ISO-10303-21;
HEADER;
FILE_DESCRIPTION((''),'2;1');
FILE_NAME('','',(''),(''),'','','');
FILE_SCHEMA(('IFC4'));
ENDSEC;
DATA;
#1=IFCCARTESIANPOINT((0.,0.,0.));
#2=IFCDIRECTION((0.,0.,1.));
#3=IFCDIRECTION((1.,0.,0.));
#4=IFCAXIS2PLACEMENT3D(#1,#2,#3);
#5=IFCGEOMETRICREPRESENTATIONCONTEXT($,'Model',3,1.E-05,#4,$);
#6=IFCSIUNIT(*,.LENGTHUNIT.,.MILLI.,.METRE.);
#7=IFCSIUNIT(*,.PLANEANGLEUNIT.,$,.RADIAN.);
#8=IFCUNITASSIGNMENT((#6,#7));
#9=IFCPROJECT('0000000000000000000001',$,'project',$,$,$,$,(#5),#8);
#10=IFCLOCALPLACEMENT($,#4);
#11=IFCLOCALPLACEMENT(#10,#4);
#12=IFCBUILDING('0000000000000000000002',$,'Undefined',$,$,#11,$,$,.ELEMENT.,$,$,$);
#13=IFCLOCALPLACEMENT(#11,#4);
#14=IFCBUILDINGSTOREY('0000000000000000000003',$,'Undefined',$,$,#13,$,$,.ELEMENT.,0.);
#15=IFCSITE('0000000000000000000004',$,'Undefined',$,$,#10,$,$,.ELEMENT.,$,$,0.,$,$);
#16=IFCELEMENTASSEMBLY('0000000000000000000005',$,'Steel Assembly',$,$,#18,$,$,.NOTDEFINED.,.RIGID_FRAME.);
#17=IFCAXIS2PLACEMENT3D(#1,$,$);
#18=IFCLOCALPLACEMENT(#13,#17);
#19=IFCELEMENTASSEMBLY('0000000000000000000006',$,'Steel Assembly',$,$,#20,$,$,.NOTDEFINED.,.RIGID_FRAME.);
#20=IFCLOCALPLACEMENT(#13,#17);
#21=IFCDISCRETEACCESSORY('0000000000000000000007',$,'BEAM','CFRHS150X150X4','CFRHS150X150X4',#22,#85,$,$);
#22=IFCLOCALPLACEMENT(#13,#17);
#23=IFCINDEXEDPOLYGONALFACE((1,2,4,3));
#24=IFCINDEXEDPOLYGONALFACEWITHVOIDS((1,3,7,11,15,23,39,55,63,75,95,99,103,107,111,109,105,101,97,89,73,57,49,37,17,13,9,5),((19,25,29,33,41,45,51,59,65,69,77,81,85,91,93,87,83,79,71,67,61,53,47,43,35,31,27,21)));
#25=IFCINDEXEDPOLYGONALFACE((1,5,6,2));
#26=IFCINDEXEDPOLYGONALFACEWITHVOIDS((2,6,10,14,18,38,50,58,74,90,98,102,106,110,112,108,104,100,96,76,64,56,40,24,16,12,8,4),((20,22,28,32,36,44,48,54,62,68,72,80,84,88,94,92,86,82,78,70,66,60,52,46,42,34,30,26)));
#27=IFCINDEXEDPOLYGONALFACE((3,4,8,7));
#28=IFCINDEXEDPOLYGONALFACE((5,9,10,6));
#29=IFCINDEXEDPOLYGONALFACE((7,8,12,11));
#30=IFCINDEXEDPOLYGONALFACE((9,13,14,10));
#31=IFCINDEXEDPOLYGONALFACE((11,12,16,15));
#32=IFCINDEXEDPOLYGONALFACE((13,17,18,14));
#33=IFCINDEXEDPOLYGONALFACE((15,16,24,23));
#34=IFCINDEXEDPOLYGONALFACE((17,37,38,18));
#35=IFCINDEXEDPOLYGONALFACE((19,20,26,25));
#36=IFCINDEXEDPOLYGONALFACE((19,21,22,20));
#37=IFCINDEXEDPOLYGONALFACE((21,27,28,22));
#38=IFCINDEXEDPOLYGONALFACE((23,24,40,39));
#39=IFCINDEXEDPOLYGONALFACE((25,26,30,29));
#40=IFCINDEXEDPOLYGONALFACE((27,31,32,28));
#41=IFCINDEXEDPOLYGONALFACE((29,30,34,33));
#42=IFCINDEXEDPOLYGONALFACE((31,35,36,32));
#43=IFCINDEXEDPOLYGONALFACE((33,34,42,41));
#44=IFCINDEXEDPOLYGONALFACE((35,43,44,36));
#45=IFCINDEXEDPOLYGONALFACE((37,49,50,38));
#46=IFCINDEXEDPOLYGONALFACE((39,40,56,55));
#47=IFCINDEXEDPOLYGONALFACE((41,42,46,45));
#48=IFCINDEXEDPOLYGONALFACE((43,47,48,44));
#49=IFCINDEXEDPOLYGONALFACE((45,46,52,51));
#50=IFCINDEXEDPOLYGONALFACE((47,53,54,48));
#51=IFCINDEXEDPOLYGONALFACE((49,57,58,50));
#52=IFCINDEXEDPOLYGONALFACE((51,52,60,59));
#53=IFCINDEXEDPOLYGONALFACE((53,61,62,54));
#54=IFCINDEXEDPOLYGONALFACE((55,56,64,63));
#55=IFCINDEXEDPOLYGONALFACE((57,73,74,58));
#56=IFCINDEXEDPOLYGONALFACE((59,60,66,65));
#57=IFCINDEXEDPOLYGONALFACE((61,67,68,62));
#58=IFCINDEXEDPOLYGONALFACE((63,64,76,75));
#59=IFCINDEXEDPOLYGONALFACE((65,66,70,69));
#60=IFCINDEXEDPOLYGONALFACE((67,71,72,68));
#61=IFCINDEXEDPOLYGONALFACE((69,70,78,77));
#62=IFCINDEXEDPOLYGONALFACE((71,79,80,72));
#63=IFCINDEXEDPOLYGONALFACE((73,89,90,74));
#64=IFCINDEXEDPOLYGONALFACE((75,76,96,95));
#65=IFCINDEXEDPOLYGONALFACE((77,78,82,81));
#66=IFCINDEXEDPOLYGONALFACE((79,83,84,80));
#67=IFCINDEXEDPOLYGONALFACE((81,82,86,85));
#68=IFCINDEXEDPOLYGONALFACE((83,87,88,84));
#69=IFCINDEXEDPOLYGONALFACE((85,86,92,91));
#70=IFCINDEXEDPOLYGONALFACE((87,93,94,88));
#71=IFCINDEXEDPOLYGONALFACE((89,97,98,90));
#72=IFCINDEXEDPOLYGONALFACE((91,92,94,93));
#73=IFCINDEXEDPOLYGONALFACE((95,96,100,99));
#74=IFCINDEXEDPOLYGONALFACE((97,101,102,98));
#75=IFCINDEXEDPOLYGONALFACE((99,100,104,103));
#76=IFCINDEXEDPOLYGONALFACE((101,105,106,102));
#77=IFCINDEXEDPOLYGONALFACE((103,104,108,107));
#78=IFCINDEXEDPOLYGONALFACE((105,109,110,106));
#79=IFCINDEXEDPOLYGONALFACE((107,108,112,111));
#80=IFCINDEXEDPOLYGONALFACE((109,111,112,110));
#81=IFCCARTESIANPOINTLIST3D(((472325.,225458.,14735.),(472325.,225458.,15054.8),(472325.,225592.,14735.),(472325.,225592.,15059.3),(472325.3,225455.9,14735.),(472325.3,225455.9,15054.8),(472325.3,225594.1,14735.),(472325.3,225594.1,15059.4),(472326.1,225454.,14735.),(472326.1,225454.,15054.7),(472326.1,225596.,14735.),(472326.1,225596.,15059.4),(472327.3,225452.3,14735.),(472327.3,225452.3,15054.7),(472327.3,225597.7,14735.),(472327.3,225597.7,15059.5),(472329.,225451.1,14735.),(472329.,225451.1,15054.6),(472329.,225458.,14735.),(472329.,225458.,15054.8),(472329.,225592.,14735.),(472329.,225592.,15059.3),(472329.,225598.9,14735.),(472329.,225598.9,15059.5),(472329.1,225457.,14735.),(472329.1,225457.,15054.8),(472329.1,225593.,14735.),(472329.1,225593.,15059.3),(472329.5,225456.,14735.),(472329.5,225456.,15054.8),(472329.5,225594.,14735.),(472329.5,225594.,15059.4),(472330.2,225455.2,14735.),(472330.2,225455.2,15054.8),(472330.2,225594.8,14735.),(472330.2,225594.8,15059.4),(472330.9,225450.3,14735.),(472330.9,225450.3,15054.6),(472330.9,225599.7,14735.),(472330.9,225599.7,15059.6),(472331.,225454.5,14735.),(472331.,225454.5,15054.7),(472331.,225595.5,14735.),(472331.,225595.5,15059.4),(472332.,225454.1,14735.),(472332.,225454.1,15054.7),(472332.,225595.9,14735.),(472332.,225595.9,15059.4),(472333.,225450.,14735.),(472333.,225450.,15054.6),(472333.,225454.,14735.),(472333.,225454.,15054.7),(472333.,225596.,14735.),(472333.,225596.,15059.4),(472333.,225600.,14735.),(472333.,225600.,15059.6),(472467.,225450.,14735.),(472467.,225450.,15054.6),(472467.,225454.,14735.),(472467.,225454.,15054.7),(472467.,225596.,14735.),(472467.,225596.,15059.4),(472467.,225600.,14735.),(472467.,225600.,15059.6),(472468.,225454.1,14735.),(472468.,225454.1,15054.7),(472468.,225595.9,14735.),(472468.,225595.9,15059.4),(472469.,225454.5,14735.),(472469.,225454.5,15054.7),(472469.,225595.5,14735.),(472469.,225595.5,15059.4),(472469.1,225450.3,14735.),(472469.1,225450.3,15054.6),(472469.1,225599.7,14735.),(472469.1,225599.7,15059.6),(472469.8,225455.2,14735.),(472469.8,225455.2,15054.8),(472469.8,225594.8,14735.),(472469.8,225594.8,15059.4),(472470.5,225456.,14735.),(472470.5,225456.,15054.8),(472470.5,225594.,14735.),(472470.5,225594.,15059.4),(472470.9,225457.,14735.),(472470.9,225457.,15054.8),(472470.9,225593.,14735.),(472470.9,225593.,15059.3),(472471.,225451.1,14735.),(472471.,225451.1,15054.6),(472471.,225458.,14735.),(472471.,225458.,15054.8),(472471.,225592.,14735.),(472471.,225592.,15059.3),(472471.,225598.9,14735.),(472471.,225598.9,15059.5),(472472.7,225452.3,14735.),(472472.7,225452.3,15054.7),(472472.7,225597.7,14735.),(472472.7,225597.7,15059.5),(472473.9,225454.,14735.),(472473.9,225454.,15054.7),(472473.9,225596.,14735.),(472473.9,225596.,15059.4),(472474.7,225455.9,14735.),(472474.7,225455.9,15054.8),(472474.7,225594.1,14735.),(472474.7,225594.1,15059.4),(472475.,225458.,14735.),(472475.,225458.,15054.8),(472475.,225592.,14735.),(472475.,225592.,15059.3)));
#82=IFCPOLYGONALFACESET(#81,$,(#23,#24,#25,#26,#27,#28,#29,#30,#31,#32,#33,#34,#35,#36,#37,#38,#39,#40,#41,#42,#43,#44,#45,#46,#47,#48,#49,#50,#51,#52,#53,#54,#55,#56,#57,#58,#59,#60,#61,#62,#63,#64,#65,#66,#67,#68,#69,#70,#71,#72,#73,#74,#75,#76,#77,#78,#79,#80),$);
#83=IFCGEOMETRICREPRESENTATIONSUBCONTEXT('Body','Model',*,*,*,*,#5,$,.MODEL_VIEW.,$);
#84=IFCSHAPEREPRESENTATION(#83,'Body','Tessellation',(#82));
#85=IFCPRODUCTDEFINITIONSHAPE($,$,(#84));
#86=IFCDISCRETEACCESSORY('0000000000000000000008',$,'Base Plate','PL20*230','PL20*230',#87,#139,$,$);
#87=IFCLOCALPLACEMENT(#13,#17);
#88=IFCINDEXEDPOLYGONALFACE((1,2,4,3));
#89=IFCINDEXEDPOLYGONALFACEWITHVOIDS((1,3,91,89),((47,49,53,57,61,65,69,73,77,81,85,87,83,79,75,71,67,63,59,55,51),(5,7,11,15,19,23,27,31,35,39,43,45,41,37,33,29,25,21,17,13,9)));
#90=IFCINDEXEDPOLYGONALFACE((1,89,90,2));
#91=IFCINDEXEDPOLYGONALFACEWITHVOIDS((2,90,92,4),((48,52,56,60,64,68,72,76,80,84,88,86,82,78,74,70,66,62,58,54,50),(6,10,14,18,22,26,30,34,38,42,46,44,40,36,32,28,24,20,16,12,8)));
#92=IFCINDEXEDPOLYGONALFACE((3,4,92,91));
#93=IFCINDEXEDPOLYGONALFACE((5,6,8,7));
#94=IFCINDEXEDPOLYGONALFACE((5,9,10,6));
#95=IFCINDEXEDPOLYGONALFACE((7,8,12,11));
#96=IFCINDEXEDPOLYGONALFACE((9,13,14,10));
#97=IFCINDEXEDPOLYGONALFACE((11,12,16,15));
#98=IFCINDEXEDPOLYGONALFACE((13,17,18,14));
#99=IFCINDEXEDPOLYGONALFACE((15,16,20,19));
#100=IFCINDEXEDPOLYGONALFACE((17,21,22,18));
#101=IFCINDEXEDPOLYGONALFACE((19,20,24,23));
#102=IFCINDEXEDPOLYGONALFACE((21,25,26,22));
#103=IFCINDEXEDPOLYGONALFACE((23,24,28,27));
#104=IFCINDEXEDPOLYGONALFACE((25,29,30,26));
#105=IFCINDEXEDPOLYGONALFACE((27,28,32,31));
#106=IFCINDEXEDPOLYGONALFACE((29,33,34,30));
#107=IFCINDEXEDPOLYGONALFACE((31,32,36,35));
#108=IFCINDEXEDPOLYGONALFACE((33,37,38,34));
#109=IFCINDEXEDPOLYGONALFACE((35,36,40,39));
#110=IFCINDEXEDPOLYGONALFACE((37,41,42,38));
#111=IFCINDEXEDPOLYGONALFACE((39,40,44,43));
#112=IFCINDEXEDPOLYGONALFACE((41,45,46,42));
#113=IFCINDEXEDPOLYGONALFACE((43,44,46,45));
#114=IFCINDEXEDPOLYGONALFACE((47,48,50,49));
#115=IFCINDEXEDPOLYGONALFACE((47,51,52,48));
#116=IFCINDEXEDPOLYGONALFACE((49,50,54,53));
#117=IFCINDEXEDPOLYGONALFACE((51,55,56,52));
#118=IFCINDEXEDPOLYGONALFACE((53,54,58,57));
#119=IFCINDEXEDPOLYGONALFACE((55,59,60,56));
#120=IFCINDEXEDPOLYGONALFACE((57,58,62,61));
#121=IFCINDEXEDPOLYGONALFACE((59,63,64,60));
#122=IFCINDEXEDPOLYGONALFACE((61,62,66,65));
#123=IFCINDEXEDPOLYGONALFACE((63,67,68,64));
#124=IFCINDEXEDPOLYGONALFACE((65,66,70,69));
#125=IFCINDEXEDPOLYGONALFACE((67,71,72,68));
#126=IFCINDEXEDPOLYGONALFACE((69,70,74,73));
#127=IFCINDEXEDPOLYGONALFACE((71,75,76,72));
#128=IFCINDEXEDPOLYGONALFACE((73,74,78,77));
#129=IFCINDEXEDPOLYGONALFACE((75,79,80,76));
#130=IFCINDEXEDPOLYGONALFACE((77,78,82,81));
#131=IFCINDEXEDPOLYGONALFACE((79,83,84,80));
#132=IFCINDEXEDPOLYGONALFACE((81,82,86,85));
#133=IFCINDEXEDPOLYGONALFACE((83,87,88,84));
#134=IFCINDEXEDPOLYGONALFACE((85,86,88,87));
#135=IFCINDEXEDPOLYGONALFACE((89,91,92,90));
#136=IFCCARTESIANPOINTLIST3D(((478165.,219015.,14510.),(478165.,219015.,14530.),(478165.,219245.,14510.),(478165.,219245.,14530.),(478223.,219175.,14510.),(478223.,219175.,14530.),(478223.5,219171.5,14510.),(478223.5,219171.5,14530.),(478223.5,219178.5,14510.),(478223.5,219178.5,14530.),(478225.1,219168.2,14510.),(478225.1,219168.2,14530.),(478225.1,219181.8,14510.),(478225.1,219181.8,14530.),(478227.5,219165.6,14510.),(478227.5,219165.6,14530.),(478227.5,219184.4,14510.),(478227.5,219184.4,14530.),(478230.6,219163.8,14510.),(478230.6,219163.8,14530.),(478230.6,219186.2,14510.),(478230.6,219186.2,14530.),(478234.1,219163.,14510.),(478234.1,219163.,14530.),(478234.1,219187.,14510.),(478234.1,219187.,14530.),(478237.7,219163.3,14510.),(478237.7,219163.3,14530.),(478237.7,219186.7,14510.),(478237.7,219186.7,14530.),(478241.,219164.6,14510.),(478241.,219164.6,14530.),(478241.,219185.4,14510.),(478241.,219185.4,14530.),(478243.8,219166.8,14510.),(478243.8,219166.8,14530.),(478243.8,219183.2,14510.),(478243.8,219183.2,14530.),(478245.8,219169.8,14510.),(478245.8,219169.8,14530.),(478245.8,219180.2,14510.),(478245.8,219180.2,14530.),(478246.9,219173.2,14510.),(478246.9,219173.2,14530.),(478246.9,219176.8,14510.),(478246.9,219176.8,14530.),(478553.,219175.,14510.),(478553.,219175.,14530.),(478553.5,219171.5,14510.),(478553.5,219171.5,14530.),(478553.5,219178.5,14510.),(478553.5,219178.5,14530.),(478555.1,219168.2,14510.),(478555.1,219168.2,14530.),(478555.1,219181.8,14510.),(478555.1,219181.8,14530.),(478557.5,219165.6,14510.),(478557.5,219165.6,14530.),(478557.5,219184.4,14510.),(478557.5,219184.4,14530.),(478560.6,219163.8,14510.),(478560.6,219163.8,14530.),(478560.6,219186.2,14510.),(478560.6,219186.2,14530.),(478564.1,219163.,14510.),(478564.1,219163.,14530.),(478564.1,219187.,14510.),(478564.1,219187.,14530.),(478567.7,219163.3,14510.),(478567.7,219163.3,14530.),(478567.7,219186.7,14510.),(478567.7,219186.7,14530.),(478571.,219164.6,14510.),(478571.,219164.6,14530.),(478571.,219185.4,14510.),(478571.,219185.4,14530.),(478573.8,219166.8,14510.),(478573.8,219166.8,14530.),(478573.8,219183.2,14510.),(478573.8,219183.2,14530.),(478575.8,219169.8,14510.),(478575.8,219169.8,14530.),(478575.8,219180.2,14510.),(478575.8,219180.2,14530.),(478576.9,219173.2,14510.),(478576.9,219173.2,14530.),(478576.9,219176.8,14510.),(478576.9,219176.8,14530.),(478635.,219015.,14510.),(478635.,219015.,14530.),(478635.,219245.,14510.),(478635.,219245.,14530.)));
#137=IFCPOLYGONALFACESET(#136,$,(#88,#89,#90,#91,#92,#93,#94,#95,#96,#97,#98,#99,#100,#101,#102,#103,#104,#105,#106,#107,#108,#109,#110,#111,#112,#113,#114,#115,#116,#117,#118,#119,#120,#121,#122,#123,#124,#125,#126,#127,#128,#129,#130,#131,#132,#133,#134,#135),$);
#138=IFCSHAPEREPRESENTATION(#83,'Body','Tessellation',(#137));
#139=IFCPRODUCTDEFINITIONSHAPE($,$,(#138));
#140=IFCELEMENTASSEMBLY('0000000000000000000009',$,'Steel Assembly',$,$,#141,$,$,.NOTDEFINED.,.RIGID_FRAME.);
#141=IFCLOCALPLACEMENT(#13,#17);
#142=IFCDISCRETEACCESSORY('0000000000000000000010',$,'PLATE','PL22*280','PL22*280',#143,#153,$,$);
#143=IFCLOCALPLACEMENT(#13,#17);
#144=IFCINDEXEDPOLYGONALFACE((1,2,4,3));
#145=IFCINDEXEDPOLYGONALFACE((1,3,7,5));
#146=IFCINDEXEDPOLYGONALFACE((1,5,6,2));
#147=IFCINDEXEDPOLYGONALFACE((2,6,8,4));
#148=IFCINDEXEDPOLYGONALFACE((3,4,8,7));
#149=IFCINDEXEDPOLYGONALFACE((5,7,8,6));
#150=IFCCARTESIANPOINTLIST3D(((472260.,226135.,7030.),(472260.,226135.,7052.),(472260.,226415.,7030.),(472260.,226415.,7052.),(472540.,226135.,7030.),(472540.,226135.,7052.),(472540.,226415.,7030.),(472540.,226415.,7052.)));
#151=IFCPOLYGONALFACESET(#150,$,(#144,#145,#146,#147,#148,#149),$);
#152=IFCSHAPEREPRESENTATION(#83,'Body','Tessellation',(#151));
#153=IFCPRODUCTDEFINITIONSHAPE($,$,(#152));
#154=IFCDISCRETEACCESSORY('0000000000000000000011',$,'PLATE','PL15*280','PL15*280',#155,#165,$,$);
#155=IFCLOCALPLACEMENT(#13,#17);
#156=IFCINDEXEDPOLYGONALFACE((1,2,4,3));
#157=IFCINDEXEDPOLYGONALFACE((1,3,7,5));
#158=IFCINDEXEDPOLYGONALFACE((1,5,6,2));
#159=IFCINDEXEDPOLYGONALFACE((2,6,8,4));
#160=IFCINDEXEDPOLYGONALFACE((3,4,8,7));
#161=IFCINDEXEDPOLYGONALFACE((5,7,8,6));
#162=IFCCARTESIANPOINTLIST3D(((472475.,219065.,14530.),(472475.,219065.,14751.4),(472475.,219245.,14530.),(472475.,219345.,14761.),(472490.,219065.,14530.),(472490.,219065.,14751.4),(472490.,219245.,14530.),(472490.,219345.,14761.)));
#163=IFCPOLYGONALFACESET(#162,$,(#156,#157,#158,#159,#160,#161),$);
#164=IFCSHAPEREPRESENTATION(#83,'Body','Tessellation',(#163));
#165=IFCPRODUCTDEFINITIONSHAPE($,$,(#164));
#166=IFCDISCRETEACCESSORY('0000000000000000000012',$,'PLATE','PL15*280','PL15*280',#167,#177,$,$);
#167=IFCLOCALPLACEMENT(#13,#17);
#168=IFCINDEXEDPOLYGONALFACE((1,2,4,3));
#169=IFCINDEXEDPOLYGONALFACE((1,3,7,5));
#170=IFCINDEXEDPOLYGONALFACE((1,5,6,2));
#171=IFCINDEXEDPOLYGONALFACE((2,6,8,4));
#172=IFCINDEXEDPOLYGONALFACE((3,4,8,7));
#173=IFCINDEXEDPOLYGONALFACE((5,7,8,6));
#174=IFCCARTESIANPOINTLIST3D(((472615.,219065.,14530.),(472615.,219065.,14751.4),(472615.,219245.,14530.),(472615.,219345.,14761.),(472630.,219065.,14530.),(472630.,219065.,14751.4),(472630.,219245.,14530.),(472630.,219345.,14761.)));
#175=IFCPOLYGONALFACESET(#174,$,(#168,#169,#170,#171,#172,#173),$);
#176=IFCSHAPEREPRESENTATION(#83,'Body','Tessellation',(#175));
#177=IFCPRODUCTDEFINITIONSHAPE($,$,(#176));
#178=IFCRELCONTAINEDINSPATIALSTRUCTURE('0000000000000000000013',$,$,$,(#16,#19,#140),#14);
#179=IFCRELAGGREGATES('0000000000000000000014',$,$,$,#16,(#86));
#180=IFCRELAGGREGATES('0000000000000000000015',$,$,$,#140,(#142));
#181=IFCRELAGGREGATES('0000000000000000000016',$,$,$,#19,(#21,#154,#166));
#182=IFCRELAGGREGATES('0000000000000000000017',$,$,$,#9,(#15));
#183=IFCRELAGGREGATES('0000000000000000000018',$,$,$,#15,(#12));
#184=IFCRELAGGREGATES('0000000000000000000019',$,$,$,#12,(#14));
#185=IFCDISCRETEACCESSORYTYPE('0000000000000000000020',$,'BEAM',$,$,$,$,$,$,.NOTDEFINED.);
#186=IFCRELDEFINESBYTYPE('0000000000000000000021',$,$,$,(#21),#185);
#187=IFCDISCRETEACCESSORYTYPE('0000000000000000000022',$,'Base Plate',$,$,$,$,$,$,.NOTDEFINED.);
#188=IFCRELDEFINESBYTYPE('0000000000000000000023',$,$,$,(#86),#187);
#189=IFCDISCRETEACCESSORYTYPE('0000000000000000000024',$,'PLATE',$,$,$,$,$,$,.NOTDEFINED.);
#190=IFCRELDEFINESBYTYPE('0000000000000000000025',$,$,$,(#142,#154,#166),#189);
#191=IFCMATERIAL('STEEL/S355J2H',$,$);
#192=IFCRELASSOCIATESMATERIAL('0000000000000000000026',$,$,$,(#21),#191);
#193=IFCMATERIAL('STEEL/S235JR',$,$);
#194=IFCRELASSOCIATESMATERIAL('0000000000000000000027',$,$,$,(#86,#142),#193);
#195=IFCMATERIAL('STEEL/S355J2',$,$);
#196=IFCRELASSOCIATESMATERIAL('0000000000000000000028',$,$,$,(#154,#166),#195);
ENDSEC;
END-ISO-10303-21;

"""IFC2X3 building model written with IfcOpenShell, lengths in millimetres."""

from ifc_helpers import new_model, si_unit, frame, origin_with_axes, origin_2d_with_axis, place, context, subcontext, project, spatial, polyline, hollow_rectangle, circle, outline, extrude, boolean, clip, halfspace, material, type_object, element, aggregate, save


model = new_model("IFC2X3")

# Units and contexts
model_context = context("Model", 3, precision=1e-05, world=origin_with_axes())
body_context = subcontext(model_context, "Body", "Model", "MODEL_VIEW")
ifc_project = project(units=[si_unit("LENGTHUNIT", "METRE", prefix="MILLI"), si_unit("PLANEANGLEUNIT", "RADIAN")], contexts=[model_context])

# Site, building, storey
site_placement = place(None, origin_with_axes())
site = spatial("IfcSite", under=ifc_project, at=site_placement, Name="Undefined", CompositionType="ELEMENT", RefElevation=0.0)
building_placement = place(site_placement, origin_with_axes())
building = spatial("IfcBuilding", under=site, at=building_placement, Name="Undefined", CompositionType="ELEMENT")
storey_placement = place(building_placement, origin_with_axes())
storey = spatial("IfcBuildingStorey", under=building, at=storey_placement, Name="Undefined", CompositionType="ELEMENT", Elevation=0.0)

# Shared definitions
ifc_material_1 = material(Name="STEEL/S235JR")

# Element assemblies, discrete accessory
assembly_1_placement = place(storey_placement, origin_with_axes())
assembly_1 = element("IfcElementAssembly", 1, at=assembly_1_placement, inside=storey, Name="Steel Assembly", AssemblyPlace="NOTDEFINED", PredefinedType="RIGID_FRAME")
ifc_material_2 = material(Name="STEEL/S355J2H")
discrete_accessory_type_1 = type_object("IfcDiscreteAccessoryType", Name="BEAM")
assembly_2_placement = place(storey_placement, origin_with_axes())
assembly_2 = element("IfcElementAssembly", 2, at=assembly_2_placement, inside=storey, Name="Steel Assembly", AssemblyPlace="NOTDEFINED", PredefinedType="RIGID_FRAME")
discrete_accessory_1_placement = place(assembly_2_placement, frame((472400.0, 225525.0, 14720.0), z_axis=(0.0, 0.0, 1.0), x_axis=(1.0, 0.0, 0.0)))
discrete_accessory_1 = element("IfcDiscreteAccessory", 3, at=discrete_accessory_1_placement, type_object=discrete_accessory_type_1, material=ifc_material_2, Name="BEAM", Description="CFRHS150X150X4", ObjectType="CFRHS150X150X4", context=body_context, shape_type="Clipping", body=[
    clip(extrude(hollow_rectangle(XDim=150.0, YDim=150.0, WallThickness=4.0, InnerFilletRadius=4.0, OuterFilletRadius=8.0, at=origin_2d_with_axis()), frame((0.0, 0.0, 339.6), z_axis=(0.0, 0.0, -1.0), x_axis=(0.0, -1.0, 0.0)), (0.0, 0.0, 1.0), 324.6), halfspace(frame((-1000.0, 2.7, 337.2), z_axis=(0.0, 0.033315, -0.999445), x_axis=(0.0, -0.999445, -0.033315)), True)),
])

# Discrete accessory
discrete_accessory_type_2 = type_object("IfcDiscreteAccessoryType", Name="Base Plate")
discrete_accessory_2_placement = place(assembly_1_placement, frame((478165.0, 219245.0, 14520.0), z_axis=(0.0, 0.0, -1.0), x_axis=(1.0, 0.0, 0.0)))
discrete_accessory_2 = element("IfcDiscreteAccessory", 4, at=discrete_accessory_2_placement, type_object=discrete_accessory_type_2, material=ifc_material_1, Name="Base Plate", Description="PL20*230", ObjectType="PL20*230", context=body_context, shape_type="CSG", body=[
    boolean("DIFFERENCE", boolean("DIFFERENCE", extrude(outline(polyline([(0.0, 0.0), (470.0, 0.0), (470.0, 230.0), (0.0, 230.0), (0.0, 0.0)])), frame((0.0, 0.0, -10.0), z_axis=(0.0, 0.0, 1.0), x_axis=(1.0, 0.0, 0.0)), (0.0, 0.0, 1.0), 20.0), extrude(circle(Radius=12.0, at=origin_2d_with_axis()), frame((70.0, 70.0, -80.0), z_axis=(0.0, 0.0, 1.0), x_axis=(-1.0, 0.0, 0.0)), (0.0, 0.0, 1.0), 1160.0)), extrude(circle(Radius=12.0, at=origin_2d_with_axis()), frame((400.0, 70.0, -80.0), z_axis=(0.0, 0.0, 1.0), x_axis=(-1.0, 0.0, 0.0)), (0.0, 0.0, 1.0), 1160.0)),
])
aggregate(assembly_1, [discrete_accessory_2])

# Element assembly, discrete accessory
assembly_3_placement = place(storey_placement, origin_with_axes())
assembly_3 = element("IfcElementAssembly", 5, at=assembly_3_placement, inside=storey, Name="Steel Assembly", AssemblyPlace="NOTDEFINED", PredefinedType="RIGID_FRAME")
discrete_accessory_type_3 = type_object("IfcDiscreteAccessoryType", Name="PLATE")
discrete_accessory_3_placement = place(assembly_3_placement, frame((472400.0, 226135.0, 7041.0), z_axis=(0.0, 0.0, 1.0), x_axis=(0.0, 1.0, 0.0)))
discrete_accessory_3 = element("IfcDiscreteAccessory", 6, at=discrete_accessory_3_placement, type_object=discrete_accessory_type_3, material=ifc_material_1, Name="PLATE", Description="PL22*280", ObjectType="PL22*280", context=body_context, shape_type="SweptSolid", body=[
    extrude(outline(polyline([(280.0, 140.0), (280.0, -140.0), (0.0, -140.0), (0.0, 140.0), (280.0, 140.0)])), frame((0.0, 0.0, -11.0), z_axis=(0.0, 0.0, 1.0), x_axis=(1.0, 0.0, 0.0)), (0.0, 0.0, 1.0), 22.0),
])
aggregate(assembly_3, [discrete_accessory_3])

# Discrete accessories
ifc_material_3 = material(Name="STEEL/S355J2")
discrete_accessory_4_placement = place(assembly_2_placement, frame((472482.5, 219065.0, 14530.0), z_axis=(1.0, 0.0, 0.0), x_axis=(0.0, 1.0, 0.0)))
discrete_accessory_4 = element("IfcDiscreteAccessory", 7, at=discrete_accessory_4_placement, type_object=discrete_accessory_type_3, material=ifc_material_3, Name="PLATE", Description="PL15*280", ObjectType="PL15*280", context=body_context, shape_type="SweptSolid", body=[
    extrude(outline(polyline([(0.0, 0.0), (180.0, 0.0), (280.0, 231.0), (0.0, 221.4), (0.0, 0.0)])), frame((0.0, 0.0, -7.5), z_axis=(0.0, 0.0, 1.0), x_axis=(1.0, 0.0, 0.0)), (0.0, 0.0, 1.0), 15.0),
])
discrete_accessory_5_placement = place(assembly_2_placement, frame((472622.5, 219065.0, 14530.0), z_axis=(1.0, 0.0, 0.0), x_axis=(0.0, 1.0, 0.0)))
discrete_accessory_5 = element("IfcDiscreteAccessory", 8, at=discrete_accessory_5_placement, type_object=discrete_accessory_type_3, material=ifc_material_3, Name="PLATE", Description="PL15*280", ObjectType="PL15*280", context=body_context, shape_type="SweptSolid", body=[
    extrude(outline(polyline([(0.0, 0.0), (180.0, 0.0), (280.0, 231.0), (0.0, 221.4), (0.0, 0.0)])), frame((0.0, 0.0, -7.5), z_axis=(0.0, 0.0, 1.0), x_axis=(1.0, 0.0, 0.0)), (0.0, 0.0, 1.0), 15.0),
])
aggregate(assembly_2, [discrete_accessory_1, discrete_accessory_4, discrete_accessory_5])

save(model, "model.ifc")
